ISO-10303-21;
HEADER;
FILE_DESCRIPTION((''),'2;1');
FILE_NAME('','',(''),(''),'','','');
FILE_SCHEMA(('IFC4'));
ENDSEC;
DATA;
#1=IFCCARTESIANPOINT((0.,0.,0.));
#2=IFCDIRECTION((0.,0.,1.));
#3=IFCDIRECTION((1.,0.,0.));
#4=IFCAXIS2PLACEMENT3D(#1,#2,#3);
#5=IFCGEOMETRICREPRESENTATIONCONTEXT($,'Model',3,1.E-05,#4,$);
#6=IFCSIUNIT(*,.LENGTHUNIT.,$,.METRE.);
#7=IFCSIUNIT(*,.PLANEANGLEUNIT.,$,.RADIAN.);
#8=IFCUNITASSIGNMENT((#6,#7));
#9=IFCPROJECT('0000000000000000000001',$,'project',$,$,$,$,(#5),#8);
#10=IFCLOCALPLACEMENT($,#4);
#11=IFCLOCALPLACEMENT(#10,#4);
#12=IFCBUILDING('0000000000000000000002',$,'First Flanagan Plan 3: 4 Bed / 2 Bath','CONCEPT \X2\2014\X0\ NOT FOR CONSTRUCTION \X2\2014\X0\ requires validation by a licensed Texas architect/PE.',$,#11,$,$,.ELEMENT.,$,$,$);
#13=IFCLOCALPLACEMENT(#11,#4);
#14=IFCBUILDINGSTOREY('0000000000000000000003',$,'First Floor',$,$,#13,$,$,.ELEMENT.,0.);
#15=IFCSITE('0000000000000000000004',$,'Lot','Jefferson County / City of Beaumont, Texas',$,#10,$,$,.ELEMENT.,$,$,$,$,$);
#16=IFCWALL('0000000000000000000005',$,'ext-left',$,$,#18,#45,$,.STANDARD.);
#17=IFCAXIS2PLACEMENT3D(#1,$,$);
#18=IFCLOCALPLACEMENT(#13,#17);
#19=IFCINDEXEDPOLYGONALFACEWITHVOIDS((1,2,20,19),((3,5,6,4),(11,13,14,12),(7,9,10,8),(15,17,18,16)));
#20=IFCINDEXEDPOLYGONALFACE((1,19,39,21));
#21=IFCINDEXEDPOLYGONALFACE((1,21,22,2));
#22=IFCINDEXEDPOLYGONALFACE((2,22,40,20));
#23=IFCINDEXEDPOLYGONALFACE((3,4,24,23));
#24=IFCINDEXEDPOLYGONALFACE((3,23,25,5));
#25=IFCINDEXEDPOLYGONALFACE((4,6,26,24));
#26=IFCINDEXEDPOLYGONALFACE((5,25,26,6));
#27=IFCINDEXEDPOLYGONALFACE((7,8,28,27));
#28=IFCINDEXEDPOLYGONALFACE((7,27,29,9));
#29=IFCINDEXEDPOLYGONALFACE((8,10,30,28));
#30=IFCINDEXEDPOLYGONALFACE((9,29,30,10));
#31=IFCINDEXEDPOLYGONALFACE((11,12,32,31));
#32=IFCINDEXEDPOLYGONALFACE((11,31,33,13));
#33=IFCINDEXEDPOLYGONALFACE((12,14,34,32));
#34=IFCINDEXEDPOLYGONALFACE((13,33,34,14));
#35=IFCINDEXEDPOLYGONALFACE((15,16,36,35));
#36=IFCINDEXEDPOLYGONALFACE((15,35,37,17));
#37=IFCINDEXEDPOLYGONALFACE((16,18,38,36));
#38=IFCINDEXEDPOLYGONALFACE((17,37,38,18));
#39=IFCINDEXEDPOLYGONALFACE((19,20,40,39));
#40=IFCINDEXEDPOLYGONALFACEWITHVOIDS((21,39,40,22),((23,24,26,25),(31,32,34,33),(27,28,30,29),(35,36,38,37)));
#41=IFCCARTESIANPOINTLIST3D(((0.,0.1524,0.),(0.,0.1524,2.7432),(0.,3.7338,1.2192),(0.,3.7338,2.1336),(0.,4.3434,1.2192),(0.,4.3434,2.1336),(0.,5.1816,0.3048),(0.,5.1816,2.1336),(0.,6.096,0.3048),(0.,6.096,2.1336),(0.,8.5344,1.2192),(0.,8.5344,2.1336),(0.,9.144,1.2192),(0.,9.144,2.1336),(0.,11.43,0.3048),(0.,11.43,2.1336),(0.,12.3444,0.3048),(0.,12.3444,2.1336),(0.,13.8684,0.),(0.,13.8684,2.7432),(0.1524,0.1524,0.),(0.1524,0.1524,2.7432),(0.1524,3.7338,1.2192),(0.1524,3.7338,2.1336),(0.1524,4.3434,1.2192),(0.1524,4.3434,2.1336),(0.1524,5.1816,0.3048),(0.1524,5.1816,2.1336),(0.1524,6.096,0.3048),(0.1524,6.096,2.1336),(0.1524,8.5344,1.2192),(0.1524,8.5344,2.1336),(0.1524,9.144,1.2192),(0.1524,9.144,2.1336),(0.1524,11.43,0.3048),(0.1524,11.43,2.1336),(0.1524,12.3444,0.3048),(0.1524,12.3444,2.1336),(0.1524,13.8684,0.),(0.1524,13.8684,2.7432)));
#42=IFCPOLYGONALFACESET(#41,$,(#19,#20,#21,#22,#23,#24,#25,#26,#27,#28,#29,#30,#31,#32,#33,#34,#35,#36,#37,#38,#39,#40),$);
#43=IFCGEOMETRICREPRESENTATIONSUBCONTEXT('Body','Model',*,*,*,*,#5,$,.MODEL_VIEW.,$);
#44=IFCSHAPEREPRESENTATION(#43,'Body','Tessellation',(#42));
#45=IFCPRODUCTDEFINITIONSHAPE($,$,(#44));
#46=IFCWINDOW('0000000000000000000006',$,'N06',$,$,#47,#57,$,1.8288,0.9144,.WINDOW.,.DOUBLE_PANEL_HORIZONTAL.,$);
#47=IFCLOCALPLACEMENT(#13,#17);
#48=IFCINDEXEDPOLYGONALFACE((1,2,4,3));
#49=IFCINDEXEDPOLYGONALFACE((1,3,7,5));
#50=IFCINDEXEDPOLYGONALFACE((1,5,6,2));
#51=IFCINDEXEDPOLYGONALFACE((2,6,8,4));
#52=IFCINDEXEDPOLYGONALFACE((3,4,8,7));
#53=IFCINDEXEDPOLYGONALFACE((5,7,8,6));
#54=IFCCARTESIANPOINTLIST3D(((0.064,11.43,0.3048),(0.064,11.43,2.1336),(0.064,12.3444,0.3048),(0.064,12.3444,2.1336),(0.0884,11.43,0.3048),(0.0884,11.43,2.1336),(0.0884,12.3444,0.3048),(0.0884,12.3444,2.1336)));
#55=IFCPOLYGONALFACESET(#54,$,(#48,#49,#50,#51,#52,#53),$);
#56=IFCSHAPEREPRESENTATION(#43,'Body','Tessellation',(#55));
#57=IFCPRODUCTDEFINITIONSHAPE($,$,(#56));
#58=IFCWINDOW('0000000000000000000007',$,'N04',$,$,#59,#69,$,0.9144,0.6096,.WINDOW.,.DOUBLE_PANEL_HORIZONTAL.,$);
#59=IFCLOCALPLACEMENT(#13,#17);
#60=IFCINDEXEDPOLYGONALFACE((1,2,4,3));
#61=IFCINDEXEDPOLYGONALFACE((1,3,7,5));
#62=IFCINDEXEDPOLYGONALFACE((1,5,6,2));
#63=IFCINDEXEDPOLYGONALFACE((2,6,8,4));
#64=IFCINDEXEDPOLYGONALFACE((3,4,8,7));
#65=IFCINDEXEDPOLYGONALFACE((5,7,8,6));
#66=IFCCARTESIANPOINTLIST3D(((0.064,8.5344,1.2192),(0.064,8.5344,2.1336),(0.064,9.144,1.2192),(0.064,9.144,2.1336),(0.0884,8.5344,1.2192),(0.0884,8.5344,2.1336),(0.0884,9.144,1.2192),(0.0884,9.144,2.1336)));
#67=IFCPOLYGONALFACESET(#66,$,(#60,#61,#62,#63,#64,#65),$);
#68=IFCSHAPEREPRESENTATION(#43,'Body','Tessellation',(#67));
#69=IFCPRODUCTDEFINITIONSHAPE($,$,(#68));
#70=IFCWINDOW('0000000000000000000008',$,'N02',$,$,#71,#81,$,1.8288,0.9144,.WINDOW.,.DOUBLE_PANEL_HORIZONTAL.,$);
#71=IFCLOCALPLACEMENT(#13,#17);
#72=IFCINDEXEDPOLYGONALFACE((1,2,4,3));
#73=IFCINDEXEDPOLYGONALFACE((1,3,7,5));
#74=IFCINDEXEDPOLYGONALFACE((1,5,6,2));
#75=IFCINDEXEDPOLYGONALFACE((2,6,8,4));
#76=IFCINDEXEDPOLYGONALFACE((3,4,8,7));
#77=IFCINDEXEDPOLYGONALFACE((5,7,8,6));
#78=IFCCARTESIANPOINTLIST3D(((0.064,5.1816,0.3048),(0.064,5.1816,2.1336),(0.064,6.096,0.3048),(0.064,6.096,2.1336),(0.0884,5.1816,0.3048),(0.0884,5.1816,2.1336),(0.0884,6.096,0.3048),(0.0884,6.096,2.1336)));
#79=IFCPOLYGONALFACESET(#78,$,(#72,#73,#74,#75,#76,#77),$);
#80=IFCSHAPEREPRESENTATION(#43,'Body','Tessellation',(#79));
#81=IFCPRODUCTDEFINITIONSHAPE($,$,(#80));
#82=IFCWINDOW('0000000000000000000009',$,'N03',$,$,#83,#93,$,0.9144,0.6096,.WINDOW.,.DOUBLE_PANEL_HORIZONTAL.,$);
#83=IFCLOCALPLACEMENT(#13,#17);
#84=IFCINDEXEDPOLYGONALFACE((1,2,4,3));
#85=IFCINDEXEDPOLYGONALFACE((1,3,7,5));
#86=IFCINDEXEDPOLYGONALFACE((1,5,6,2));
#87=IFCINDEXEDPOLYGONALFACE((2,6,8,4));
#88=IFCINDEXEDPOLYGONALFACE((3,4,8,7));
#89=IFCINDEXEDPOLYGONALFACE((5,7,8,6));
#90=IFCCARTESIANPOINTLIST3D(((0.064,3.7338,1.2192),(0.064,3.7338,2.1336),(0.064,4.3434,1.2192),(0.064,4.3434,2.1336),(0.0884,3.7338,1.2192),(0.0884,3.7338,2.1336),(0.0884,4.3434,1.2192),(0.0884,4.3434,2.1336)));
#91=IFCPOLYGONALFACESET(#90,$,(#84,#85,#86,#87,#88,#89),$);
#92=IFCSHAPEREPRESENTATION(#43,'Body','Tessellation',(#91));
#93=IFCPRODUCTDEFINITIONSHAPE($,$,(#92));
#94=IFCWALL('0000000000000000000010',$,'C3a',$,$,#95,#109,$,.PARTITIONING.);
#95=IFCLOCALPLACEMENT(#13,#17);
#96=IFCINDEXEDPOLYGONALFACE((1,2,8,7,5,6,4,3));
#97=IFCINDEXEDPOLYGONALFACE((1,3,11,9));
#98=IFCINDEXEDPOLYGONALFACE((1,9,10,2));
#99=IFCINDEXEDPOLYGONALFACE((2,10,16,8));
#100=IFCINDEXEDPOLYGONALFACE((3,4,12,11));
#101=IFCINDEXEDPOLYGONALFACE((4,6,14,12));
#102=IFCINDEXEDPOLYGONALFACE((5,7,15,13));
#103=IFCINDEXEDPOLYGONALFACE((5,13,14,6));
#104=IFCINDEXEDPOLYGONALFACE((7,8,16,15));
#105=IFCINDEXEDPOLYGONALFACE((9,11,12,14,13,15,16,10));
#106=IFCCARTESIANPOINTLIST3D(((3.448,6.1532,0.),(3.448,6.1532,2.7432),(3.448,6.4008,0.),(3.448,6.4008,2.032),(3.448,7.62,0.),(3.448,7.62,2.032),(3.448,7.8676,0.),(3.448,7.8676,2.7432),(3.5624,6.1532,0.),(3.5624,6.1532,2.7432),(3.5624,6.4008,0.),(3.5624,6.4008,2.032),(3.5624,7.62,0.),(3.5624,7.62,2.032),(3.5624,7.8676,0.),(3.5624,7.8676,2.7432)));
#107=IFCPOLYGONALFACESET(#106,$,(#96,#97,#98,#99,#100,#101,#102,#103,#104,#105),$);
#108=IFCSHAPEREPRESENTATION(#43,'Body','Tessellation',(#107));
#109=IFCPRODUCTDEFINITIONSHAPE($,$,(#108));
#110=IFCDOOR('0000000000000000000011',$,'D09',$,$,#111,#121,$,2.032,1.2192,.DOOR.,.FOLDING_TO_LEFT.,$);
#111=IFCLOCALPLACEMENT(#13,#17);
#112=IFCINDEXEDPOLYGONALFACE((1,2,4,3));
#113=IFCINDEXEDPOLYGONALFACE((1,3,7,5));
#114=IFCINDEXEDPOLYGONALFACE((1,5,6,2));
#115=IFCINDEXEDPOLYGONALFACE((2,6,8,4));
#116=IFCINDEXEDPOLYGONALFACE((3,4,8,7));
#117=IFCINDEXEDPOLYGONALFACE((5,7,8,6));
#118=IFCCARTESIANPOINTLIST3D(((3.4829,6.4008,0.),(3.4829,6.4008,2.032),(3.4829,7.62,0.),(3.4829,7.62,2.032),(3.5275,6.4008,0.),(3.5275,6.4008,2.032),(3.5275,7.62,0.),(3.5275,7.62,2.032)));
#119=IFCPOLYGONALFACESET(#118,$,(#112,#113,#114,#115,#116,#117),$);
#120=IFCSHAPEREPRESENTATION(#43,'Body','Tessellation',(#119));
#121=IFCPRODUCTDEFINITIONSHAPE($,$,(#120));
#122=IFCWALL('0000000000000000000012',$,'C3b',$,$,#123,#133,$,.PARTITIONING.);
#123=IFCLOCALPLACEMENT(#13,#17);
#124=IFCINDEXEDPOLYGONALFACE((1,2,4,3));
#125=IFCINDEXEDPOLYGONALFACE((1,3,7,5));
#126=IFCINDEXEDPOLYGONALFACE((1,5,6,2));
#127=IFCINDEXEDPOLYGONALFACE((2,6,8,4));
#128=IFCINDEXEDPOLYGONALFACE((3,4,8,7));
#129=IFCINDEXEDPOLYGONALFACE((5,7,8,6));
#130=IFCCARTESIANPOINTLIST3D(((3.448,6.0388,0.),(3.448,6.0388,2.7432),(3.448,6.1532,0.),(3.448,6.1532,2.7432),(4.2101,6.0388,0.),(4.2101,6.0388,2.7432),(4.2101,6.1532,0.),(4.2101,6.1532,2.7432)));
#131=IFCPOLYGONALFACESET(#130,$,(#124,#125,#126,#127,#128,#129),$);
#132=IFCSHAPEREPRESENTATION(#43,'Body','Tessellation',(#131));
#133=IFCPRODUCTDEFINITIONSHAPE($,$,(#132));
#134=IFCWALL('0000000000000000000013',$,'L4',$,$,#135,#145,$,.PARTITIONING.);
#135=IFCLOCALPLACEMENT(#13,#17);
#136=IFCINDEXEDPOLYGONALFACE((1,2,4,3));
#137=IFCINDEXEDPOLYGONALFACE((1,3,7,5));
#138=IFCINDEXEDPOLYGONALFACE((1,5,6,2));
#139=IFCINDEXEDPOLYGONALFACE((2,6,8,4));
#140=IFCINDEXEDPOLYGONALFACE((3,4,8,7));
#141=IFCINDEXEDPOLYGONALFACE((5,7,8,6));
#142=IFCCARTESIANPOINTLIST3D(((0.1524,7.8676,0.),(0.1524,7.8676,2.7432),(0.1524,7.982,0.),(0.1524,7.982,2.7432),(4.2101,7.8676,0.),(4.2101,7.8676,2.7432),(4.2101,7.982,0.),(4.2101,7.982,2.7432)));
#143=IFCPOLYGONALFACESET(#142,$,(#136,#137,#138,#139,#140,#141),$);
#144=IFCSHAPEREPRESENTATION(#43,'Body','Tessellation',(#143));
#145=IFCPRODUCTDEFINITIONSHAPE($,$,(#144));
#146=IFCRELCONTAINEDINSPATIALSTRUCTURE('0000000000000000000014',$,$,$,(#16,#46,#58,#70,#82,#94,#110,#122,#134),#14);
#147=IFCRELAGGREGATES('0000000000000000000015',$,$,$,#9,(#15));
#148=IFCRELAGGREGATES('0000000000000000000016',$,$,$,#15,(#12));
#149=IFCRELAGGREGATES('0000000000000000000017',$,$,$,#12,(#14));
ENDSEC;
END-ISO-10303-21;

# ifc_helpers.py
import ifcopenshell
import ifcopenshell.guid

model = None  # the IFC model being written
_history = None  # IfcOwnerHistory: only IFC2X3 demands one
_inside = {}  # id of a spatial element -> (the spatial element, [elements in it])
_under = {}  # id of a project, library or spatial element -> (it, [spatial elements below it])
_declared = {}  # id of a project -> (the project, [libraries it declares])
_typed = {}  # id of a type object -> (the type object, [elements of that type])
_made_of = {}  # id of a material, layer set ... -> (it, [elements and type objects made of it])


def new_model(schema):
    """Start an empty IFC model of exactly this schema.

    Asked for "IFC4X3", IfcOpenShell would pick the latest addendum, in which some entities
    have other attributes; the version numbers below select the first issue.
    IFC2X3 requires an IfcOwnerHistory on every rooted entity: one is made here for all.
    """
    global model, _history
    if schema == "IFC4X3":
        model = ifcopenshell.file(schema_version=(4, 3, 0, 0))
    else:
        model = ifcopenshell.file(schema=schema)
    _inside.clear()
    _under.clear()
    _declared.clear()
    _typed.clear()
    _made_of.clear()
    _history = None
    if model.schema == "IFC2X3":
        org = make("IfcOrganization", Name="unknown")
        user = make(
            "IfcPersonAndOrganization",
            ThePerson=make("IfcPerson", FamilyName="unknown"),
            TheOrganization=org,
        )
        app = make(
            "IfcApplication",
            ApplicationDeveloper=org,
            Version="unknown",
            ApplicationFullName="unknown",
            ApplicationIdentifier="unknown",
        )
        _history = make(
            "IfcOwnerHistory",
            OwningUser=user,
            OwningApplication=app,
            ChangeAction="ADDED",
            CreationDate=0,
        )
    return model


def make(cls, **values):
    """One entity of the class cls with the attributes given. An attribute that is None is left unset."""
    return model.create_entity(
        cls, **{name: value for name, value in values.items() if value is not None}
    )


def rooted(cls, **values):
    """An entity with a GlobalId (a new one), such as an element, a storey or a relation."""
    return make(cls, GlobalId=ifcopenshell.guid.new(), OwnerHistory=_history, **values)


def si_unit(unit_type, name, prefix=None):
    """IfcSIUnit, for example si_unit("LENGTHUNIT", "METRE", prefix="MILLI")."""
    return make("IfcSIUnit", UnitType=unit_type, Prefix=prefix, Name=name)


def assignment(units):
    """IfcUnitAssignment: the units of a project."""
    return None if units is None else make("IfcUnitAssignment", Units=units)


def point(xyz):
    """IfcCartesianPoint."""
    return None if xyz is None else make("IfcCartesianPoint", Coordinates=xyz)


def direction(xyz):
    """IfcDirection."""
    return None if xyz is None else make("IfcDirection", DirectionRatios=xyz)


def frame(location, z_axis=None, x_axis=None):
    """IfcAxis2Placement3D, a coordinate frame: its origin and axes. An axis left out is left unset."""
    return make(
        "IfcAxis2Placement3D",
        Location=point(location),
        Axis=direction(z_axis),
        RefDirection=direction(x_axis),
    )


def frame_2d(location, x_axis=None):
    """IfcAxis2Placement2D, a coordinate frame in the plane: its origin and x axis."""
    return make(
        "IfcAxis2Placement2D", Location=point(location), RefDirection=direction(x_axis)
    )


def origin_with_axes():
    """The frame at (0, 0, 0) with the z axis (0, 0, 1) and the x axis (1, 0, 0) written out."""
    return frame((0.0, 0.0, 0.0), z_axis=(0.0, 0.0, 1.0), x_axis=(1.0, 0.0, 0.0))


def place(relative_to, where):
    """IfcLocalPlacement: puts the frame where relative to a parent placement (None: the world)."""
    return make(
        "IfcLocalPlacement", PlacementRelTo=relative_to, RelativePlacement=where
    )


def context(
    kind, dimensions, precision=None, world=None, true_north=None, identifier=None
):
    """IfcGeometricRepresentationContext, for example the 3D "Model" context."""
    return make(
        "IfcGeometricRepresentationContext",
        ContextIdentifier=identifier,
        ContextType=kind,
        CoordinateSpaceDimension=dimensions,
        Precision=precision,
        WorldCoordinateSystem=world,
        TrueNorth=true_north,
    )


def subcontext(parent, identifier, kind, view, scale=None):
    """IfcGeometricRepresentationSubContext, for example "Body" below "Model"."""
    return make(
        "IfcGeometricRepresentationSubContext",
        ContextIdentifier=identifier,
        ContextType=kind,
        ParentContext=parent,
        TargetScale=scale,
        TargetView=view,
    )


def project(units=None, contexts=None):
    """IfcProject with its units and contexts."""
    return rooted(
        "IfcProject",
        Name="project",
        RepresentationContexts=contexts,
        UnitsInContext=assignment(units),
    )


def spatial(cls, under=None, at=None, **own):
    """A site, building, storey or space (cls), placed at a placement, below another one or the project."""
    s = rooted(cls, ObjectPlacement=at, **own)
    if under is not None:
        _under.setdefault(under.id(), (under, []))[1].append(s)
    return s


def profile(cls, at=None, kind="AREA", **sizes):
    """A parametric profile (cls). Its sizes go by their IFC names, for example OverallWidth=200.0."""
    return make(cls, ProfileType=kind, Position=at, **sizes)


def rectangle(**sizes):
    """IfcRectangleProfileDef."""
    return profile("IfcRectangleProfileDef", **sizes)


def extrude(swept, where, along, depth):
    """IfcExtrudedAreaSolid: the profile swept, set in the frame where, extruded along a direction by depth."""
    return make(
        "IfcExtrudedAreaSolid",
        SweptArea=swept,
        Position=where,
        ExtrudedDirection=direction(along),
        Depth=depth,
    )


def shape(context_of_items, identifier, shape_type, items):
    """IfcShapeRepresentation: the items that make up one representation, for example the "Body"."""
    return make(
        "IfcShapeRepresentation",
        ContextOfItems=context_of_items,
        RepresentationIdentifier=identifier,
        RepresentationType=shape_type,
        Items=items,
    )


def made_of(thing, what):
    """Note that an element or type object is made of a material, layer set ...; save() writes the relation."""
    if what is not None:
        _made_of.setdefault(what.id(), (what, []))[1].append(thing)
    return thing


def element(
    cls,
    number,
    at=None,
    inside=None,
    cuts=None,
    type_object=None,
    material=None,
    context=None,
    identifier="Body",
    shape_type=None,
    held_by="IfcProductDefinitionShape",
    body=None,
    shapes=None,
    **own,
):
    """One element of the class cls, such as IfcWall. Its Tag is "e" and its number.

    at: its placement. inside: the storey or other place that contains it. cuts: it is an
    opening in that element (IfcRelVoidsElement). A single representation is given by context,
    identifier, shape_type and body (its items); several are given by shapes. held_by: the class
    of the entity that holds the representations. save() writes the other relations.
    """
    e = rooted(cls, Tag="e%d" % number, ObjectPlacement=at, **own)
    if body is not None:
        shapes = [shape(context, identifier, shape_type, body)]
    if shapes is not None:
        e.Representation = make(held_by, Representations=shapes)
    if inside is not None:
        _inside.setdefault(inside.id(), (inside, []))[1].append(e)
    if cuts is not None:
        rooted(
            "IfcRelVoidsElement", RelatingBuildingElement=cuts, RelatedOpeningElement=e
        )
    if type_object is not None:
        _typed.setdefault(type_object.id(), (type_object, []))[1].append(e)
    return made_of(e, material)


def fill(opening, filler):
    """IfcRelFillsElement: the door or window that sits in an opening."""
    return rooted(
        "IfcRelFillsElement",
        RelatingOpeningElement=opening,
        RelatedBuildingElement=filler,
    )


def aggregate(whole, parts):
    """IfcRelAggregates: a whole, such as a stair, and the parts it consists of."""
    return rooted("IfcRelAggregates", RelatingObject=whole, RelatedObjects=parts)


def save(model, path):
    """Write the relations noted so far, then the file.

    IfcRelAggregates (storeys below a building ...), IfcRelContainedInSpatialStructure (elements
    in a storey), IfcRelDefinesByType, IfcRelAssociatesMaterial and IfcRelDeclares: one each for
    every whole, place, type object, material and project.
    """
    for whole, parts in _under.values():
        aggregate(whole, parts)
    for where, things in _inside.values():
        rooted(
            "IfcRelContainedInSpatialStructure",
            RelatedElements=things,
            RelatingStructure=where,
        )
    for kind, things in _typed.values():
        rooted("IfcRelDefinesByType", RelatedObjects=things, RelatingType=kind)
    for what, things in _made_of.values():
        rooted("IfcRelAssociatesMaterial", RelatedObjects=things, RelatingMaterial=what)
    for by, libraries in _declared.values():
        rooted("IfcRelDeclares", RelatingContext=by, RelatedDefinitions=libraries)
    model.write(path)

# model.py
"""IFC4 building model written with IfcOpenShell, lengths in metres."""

from ifc_helpers import new_model, si_unit, frame, frame_2d, origin_with_axes, place, context, subcontext, project, spatial, rectangle, extrude, element, fill, save


model = new_model("IFC4")

# Units and contexts
model_context = context("Model", 3, precision=1e-05, world=origin_with_axes())
body_context = subcontext(model_context, "Body", "Model", "MODEL_VIEW")
ifc_project = project(units=[si_unit("LENGTHUNIT", "METRE"), si_unit("PLANEANGLEUNIT", "RADIAN")], contexts=[model_context])

# Site, building, storey
site_placement = place(None, origin_with_axes())
site = spatial("IfcSite", under=ifc_project, at=site_placement, Name="Lot", Description="Jefferson County / City of Beaumont, Texas", CompositionType="ELEMENT")
building_placement = place(site_placement, origin_with_axes())
building = spatial("IfcBuilding", under=site, at=building_placement, Name="First Flanagan Plan 3: 4 Bed / 2 Bath", Description="CONCEPT — NOT FOR CONSTRUCTION — requires validation by a licensed Texas architect/PE.", CompositionType="ELEMENT")
storey_placement = place(building_placement, origin_with_axes())
storey = spatial("IfcBuildingStorey", under=building, at=storey_placement, Name="First Floor", CompositionType="ELEMENT", Elevation=0.0)

# Wall, openings, windows
wall_1_placement = place(storey_placement, frame((0.0762, 13.8684, 0.0), z_axis=(0.0, 0.0, 1.0), x_axis=(0.0, -1.0, 0.0)))
wall_1 = element("IfcWall", 1, at=wall_1_placement, inside=storey, Name="ext-left", PredefinedType="STANDARD", context=body_context, shape_type="SweptSolid", body=[
    extrude(rectangle(XDim=13.716, YDim=0.1524, at=frame_2d((6.858, 0.0), x_axis=(1.0, 0.0))), origin_with_axes(), (0.0, 0.0, 1.0), 2.7432),
])
opening_1_placement = place(wall_1_placement, frame((1.524, 0.0, 0.3048), z_axis=(0.0, 0.0, 1.0), x_axis=(1.0, 0.0, 0.0)))
opening_1 = element("IfcOpeningElement", 2, at=opening_1_placement, cuts=wall_1, PredefinedType="OPENING", context=body_context, shape_type="SweptSolid", body=[
    extrude(rectangle(XDim=0.9144, YDim=0.1829, at=frame_2d((0.4572, 0.0), x_axis=(1.0, 0.0))), origin_with_axes(), (0.0, 0.0, 1.0), 1.8288),
])
opening_2_placement = place(wall_1_placement, frame((4.7244, 0.0, 1.2192), z_axis=(0.0, 0.0, 1.0), x_axis=(1.0, 0.0, 0.0)))
opening_2 = element("IfcOpeningElement", 3, at=opening_2_placement, cuts=wall_1, PredefinedType="OPENING", context=body_context, shape_type="SweptSolid", body=[
    extrude(rectangle(XDim=0.6096, YDim=0.1829, at=frame_2d((0.3048, 0.0), x_axis=(1.0, 0.0))), origin_with_axes(), (0.0, 0.0, 1.0), 0.9144),
])
opening_3_placement = place(wall_1_placement, frame((7.7724, 0.0, 0.3048), z_axis=(0.0, 0.0, 1.0), x_axis=(1.0, 0.0, 0.0)))
opening_3 = element("IfcOpeningElement", 4, at=opening_3_placement, cuts=wall_1, PredefinedType="OPENING", context=body_context, shape_type="SweptSolid", body=[
    extrude(rectangle(XDim=0.9144, YDim=0.1829, at=frame_2d((0.4572, 0.0), x_axis=(1.0, 0.0))), origin_with_axes(), (0.0, 0.0, 1.0), 1.8288),
])
opening_4_placement = place(wall_1_placement, frame((9.525, 0.0, 1.2192), z_axis=(0.0, 0.0, 1.0), x_axis=(1.0, 0.0, 0.0)))
opening_4 = element("IfcOpeningElement", 5, at=opening_4_placement, cuts=wall_1, PredefinedType="OPENING", context=body_context, shape_type="SweptSolid", body=[
    extrude(rectangle(XDim=0.6096, YDim=0.1829, at=frame_2d((0.3048, 0.0), x_axis=(1.0, 0.0))), origin_with_axes(), (0.0, 0.0, 1.0), 0.9144),
])
window_1_placement = place(opening_1_placement, origin_with_axes())
window_1 = element("IfcWindow", 6, at=window_1_placement, inside=storey, Name="N06", OverallHeight=1.8288, OverallWidth=0.9144, PartitioningType="DOUBLE_PANEL_HORIZONTAL", PredefinedType="WINDOW", context=body_context, shape_type="SweptSolid", body=[
    extrude(rectangle(XDim=0.9144, YDim=0.0244, at=frame_2d((0.4572, 0.0), x_axis=(1.0, 0.0))), origin_with_axes(), (0.0, 0.0, 1.0), 1.8288),
])
fill(opening_1, window_1)
window_2_placement = place(opening_2_placement, origin_with_axes())
window_2 = element("IfcWindow", 7, at=window_2_placement, inside=storey, Name="N04", OverallHeight=0.9144, OverallWidth=0.6096, PartitioningType="DOUBLE_PANEL_HORIZONTAL", PredefinedType="WINDOW", context=body_context, shape_type="SweptSolid", body=[
    extrude(rectangle(XDim=0.6096, YDim=0.0244, at=frame_2d((0.3048, 0.0), x_axis=(1.0, 0.0))), origin_with_axes(), (0.0, 0.0, 1.0), 0.9144),
])
fill(opening_2, window_2)
window_3_placement = place(opening_3_placement, origin_with_axes())
window_3 = element("IfcWindow", 8, at=window_3_placement, inside=storey, Name="N02", OverallHeight=1.8288, OverallWidth=0.9144, PartitioningType="DOUBLE_PANEL_HORIZONTAL", PredefinedType="WINDOW", context=body_context, shape_type="SweptSolid", body=[
    extrude(rectangle(XDim=0.9144, YDim=0.0244, at=frame_2d((0.4572, 0.0), x_axis=(1.0, 0.0))), origin_with_axes(), (0.0, 0.0, 1.0), 1.8288),
])
fill(opening_3, window_3)
window_4_placement = place(opening_4_placement, origin_with_axes())
window_4 = element("IfcWindow", 9, at=window_4_placement, inside=storey, Name="N03", OverallHeight=0.9144, OverallWidth=0.6096, PartitioningType="DOUBLE_PANEL_HORIZONTAL", PredefinedType="WINDOW", context=body_context, shape_type="SweptSolid", body=[
    extrude(rectangle(XDim=0.6096, YDim=0.0244, at=frame_2d((0.3048, 0.0), x_axis=(1.0, 0.0))), origin_with_axes(), (0.0, 0.0, 1.0), 0.9144),
])
fill(opening_4, window_4)

# Wall, opening, door
wall_2_placement = place(storey_placement, frame((3.5052, 6.1532, 0.0), z_axis=(0.0, 0.0, 1.0), x_axis=(0.0, 1.0, 0.0)))
wall_2 = element("IfcWall", 10, at=wall_2_placement, inside=storey, Name="C3a", PredefinedType="PARTITIONING", context=body_context, shape_type="SweptSolid", body=[
    extrude(rectangle(XDim=1.7145, YDim=0.1143, at=frame_2d((0.8573, 0.0), x_axis=(1.0, 0.0))), origin_with_axes(), (0.0, 0.0, 1.0), 2.7432),
])
opening_5_placement = place(wall_2_placement, frame((0.2477, 0.0, 0.0), z_axis=(0.0, 0.0, 1.0), x_axis=(1.0, 0.0, 0.0)))
opening_5 = element("IfcOpeningElement", 11, at=opening_5_placement, cuts=wall_2, PredefinedType="OPENING", context=body_context, shape_type="SweptSolid", body=[
    extrude(rectangle(XDim=1.2192, YDim=0.1448, at=frame_2d((0.6096, 0.0), x_axis=(1.0, 0.0))), origin_with_axes(), (0.0, 0.0, 1.0), 2.032),
])
door_1_placement = place(opening_5_placement, origin_with_axes())
door_1 = element("IfcDoor", 12, at=door_1_placement, inside=storey, Name="D09", OperationType="FOLDING_TO_LEFT", OverallHeight=2.032, OverallWidth=1.2192, PredefinedType="DOOR", context=body_context, shape_type="SweptSolid", body=[
    extrude(rectangle(XDim=1.2192, YDim=0.0445, at=frame_2d((0.6096, 0.0), x_axis=(1.0, 0.0))), origin_with_axes(), (0.0, 0.0, 1.0), 2.032),
])
fill(opening_5, door_1)

# Walls
wall_3_placement = place(storey_placement, frame((3.4481, 6.096, 0.0), z_axis=(0.0, 0.0, 1.0), x_axis=(1.0, 0.0, 0.0)))
element("IfcWall", 13, at=wall_3_placement, inside=storey, Name="C3b", PredefinedType="PARTITIONING", context=body_context, shape_type="SweptSolid", body=[
    extrude(rectangle(XDim=0.762, YDim=0.1143, at=frame_2d((0.381, 0.0), x_axis=(1.0, 0.0))), origin_with_axes(), (0.0, 0.0, 1.0), 2.7432),
])
wall_4_placement = place(storey_placement, frame((0.1524, 7.9248, 0.0), z_axis=(0.0, 0.0, 1.0), x_axis=(1.0, 0.0, 0.0)))
element("IfcWall", 14, at=wall_4_placement, inside=storey, Name="L4", PredefinedType="PARTITIONING", context=body_context, shape_type="SweptSolid", body=[
    extrude(rectangle(XDim=4.0577, YDim=0.1143, at=frame_2d((2.0288, 0.0), x_axis=(1.0, 0.0))), origin_with_axes(), (0.0, 0.0, 1.0), 2.7432),
])

save(model, "model.ifc")
